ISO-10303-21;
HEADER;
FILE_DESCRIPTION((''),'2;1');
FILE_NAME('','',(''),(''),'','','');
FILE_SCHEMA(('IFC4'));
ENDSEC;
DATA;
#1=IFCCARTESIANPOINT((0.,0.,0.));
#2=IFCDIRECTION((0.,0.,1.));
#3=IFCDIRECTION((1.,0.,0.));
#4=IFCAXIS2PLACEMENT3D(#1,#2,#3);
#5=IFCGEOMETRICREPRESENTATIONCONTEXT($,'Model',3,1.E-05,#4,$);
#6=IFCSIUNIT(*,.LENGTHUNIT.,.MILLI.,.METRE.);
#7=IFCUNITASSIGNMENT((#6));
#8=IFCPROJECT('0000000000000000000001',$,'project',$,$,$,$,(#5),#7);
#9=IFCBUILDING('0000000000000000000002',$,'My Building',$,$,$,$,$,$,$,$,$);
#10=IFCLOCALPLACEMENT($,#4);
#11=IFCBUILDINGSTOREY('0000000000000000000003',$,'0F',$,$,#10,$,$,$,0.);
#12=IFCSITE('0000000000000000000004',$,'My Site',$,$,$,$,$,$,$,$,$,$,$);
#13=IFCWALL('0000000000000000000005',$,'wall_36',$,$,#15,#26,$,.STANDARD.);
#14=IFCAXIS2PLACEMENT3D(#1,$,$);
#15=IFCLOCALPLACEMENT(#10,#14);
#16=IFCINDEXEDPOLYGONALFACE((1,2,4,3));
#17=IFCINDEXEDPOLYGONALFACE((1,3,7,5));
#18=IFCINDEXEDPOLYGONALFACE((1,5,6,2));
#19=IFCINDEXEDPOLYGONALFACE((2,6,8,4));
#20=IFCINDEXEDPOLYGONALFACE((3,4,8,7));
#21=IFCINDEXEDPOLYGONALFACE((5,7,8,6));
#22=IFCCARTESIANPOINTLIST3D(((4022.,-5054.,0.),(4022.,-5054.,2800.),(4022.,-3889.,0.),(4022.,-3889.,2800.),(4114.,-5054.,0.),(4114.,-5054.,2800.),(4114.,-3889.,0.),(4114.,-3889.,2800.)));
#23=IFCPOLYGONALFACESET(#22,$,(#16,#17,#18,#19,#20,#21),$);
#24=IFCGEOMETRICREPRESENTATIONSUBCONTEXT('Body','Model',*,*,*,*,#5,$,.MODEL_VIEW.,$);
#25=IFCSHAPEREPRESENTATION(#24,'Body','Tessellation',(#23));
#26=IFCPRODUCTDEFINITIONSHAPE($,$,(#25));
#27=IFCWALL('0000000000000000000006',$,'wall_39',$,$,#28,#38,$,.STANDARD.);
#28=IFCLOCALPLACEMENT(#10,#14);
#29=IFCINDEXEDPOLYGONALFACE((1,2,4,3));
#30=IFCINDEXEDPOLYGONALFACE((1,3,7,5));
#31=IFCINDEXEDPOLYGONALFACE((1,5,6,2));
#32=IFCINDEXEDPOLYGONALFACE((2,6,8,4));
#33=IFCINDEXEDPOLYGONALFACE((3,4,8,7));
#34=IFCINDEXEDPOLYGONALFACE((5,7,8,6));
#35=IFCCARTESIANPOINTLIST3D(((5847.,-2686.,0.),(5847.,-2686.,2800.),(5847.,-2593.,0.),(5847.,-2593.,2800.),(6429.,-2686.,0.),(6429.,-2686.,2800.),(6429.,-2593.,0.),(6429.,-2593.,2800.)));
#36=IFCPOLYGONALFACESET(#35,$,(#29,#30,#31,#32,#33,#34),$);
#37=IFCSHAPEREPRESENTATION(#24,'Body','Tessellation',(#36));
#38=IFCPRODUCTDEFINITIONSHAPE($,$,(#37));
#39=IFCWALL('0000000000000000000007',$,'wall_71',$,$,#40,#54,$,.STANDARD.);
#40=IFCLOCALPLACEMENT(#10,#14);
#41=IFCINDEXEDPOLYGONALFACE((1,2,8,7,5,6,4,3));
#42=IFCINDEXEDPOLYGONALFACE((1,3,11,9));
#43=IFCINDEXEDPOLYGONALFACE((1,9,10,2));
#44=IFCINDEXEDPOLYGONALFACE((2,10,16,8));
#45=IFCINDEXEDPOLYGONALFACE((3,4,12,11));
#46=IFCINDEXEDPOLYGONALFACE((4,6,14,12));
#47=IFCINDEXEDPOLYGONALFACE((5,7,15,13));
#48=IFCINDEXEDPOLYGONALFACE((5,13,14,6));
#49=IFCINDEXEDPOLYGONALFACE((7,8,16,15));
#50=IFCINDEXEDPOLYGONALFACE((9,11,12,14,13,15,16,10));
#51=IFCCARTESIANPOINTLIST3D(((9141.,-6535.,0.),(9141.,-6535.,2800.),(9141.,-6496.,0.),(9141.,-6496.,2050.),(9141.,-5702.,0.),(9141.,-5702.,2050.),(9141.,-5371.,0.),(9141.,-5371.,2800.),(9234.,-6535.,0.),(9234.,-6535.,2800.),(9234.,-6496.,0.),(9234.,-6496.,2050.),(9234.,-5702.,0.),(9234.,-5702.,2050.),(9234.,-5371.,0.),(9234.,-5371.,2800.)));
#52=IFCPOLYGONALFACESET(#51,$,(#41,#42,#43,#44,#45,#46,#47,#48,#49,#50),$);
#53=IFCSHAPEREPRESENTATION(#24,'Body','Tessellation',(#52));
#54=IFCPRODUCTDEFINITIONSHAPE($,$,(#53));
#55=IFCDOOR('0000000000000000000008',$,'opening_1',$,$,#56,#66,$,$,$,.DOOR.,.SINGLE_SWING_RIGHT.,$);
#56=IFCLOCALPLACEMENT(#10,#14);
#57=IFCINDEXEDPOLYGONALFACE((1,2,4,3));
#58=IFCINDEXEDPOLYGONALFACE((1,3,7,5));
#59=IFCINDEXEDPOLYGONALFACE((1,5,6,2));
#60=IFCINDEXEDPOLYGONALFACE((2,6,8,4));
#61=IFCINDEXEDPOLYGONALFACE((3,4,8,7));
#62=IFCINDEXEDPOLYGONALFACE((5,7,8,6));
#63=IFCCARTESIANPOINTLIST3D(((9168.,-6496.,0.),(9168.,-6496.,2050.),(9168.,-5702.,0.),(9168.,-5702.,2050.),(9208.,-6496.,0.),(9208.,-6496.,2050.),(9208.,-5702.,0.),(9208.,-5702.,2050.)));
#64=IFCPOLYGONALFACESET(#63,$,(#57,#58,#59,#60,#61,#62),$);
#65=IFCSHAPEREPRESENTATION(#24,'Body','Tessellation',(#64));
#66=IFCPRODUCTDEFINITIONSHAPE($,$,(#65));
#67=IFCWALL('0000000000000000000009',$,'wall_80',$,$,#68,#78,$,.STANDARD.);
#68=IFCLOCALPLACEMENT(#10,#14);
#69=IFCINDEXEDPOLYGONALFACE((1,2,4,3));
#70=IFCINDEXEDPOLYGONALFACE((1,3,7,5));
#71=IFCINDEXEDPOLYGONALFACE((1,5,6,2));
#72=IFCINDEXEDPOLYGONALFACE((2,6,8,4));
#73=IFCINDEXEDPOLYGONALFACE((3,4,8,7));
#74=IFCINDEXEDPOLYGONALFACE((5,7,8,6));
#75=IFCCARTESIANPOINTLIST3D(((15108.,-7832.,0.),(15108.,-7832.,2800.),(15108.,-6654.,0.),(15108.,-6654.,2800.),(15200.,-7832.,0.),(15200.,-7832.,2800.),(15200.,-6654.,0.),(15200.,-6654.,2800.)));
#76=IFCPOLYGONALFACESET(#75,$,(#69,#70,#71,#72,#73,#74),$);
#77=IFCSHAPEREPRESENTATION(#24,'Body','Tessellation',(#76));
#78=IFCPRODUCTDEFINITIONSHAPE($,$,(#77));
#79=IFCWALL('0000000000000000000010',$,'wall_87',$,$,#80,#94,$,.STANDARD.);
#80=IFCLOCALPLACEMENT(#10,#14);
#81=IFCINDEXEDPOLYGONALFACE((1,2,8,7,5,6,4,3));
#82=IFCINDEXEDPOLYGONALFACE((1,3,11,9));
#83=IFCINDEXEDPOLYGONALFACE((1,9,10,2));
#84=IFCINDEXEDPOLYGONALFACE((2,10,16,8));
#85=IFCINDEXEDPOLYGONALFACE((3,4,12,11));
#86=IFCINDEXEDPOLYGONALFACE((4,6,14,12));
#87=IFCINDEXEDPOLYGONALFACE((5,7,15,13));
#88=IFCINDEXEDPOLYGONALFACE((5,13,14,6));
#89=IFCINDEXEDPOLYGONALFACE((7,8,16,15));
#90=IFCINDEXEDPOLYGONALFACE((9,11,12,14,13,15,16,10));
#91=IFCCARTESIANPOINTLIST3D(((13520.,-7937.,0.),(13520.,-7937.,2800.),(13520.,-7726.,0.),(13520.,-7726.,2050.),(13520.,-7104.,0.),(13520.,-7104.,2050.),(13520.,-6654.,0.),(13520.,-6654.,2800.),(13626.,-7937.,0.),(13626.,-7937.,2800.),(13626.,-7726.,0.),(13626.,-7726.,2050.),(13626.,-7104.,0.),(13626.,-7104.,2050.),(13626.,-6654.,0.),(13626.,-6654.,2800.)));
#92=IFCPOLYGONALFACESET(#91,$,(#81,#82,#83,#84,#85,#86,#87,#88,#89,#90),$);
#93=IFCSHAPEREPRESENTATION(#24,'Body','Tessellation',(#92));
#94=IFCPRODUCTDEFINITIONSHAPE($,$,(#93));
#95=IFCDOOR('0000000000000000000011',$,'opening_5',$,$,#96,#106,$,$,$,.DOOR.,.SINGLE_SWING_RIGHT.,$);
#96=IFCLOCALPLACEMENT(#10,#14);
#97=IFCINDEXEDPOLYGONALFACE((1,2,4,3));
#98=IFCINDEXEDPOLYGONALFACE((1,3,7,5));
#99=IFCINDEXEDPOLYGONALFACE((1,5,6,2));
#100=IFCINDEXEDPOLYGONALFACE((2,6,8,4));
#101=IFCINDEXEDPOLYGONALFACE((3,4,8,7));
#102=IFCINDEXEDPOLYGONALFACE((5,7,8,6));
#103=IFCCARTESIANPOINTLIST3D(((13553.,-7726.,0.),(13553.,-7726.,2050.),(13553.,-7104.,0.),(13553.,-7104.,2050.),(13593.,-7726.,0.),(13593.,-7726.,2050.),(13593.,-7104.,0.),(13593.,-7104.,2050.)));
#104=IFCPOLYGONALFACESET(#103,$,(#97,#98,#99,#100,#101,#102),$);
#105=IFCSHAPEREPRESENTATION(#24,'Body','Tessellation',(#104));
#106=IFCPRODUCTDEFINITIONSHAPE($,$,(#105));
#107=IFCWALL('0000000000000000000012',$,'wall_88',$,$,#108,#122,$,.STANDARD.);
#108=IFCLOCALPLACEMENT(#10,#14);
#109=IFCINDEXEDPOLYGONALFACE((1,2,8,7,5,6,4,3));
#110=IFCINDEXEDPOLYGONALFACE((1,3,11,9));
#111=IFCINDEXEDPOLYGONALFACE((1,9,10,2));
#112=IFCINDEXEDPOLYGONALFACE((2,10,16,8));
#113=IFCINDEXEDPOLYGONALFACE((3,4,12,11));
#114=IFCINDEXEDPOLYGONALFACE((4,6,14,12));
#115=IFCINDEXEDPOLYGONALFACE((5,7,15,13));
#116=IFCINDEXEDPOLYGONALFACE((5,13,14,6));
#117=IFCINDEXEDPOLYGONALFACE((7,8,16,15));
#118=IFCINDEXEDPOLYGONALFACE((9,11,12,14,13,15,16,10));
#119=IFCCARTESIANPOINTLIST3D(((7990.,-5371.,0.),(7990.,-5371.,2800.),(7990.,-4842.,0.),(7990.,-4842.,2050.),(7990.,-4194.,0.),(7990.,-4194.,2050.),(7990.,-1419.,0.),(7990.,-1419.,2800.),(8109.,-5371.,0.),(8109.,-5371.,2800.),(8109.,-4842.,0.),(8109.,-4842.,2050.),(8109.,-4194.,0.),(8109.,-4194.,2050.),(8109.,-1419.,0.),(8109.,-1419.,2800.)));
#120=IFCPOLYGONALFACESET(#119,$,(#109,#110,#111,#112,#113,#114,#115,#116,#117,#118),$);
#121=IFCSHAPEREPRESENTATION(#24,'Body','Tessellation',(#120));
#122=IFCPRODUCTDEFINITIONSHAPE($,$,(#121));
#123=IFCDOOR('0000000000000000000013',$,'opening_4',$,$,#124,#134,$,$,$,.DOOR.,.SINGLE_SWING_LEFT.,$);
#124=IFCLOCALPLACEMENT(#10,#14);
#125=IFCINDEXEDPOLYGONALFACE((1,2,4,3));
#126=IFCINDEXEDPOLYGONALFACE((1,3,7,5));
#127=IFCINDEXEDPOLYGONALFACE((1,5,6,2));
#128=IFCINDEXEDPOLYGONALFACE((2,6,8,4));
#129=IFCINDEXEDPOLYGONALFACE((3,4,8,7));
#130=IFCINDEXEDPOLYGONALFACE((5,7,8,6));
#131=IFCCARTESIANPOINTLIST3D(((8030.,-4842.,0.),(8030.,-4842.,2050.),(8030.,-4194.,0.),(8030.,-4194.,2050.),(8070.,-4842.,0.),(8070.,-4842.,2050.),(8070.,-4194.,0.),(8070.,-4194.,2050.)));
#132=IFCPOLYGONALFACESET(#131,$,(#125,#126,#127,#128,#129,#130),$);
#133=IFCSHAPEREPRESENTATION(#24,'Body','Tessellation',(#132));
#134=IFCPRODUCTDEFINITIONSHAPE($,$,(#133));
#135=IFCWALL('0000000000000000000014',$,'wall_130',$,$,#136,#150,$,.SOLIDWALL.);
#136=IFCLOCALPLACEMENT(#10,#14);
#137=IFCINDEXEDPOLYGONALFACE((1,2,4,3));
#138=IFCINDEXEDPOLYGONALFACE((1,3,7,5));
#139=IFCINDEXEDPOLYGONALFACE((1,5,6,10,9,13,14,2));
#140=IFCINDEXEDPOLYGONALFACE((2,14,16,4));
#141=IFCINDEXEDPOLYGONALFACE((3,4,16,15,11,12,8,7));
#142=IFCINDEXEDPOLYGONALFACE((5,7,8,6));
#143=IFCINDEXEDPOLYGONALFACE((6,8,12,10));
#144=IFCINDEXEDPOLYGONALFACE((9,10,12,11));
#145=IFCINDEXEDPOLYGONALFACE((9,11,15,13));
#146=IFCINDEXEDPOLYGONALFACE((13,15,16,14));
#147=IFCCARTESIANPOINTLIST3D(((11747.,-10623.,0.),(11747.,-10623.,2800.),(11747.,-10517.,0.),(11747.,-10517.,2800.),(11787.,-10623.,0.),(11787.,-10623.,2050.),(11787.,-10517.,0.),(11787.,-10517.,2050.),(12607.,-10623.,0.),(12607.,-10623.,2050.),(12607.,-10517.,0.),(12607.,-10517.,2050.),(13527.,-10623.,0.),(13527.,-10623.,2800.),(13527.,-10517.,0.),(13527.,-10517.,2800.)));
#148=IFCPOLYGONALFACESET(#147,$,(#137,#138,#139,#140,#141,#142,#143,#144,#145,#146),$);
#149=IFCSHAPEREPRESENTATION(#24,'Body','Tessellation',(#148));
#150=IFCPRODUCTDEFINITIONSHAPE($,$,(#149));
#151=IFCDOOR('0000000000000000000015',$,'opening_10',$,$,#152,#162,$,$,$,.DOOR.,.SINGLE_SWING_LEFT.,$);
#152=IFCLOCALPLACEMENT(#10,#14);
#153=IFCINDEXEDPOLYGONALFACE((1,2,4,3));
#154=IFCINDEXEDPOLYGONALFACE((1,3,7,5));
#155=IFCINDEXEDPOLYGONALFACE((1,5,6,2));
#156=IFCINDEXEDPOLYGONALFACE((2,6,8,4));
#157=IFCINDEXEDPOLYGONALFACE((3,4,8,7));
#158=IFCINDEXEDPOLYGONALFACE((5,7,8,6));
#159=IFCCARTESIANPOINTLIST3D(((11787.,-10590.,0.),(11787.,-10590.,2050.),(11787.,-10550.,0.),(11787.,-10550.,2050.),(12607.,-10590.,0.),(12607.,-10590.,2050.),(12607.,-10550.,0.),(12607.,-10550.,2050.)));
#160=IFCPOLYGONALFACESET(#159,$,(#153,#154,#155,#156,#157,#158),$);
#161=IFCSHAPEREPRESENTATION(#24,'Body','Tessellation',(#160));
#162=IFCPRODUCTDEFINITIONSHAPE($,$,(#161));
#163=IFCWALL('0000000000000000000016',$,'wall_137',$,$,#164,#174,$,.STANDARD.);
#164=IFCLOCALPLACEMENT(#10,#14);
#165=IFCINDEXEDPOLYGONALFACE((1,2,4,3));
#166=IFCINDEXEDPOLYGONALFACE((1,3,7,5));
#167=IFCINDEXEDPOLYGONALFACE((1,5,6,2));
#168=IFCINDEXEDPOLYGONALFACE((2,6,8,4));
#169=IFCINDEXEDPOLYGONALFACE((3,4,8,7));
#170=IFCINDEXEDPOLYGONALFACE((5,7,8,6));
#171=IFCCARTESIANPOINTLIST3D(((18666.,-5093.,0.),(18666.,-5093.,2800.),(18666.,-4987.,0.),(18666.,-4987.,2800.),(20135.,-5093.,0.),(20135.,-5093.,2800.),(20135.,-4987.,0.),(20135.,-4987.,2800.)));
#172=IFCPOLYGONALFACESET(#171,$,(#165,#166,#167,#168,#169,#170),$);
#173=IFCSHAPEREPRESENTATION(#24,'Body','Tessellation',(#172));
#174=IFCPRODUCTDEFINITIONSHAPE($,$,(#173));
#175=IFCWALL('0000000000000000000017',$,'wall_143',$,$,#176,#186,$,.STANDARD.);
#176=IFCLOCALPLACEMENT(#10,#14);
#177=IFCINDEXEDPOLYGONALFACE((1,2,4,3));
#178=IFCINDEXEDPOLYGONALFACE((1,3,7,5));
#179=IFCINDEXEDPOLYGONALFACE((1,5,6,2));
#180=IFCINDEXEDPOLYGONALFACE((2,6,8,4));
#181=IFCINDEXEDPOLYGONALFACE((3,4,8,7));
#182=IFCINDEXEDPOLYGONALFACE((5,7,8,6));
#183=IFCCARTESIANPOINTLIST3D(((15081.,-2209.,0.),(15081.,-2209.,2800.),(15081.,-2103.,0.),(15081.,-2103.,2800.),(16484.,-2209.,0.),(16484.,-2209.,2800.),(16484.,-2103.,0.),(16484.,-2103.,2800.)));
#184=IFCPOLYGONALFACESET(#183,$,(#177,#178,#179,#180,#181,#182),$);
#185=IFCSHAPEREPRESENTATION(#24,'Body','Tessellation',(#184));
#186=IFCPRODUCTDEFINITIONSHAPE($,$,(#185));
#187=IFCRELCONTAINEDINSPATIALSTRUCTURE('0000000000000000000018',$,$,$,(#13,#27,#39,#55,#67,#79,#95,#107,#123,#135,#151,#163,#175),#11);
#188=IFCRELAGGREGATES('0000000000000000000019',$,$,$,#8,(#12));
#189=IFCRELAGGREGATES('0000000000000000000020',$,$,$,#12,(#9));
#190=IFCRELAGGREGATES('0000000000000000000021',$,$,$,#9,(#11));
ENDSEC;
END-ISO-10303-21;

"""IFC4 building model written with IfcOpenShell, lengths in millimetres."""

from ifc_helpers import new_model, si_unit, origin_with_axes, place, context, subcontext, project, spatial, indexed_curve, outline, extrude, element, fill, save


model = new_model("IFC4")

# Units and contexts
model_context = context("Model", 3, precision=1e-05, world=origin_with_axes())
body_context = subcontext(model_context, "Body", "Model", "MODEL_VIEW")
ifc_project = project(units=[si_unit("LENGTHUNIT", "METRE", prefix="MILLI")], contexts=[model_context])

# Site, building, storey
site = spatial("IfcSite", under=ifc_project, Name="My Site")
building = spatial("IfcBuilding", under=site, Name="My Building")
storey_placement = place(None, origin_with_axes())
storey = spatial("IfcBuildingStorey", under=building, at=storey_placement, Name="0F", Elevation=0.0)

# Walls
wall_1_placement = place(storey_placement, origin_with_axes())
element("IfcWall", 1, at=wall_1_placement, inside=storey, Name="wall_36", PredefinedType="STANDARD", context=body_context, shape_type="SweptSolid", body=[
    extrude(outline(indexed_curve([(4022.0, -3889.0), (4022.0, -5054.0), (4114.0, -5054.0), (4114.0, -3889.0), (4022.0, -3889.0)])), None, (0.0, 0.0, 1.0), 2800.0),
])
wall_2_placement = place(storey_placement, origin_with_axes())
element("IfcWall", 2, at=wall_2_placement, inside=storey, Name="wall_39", PredefinedType="STANDARD", context=body_context, shape_type="SweptSolid", body=[
    extrude(outline(indexed_curve([(5847.0, -2686.0), (6429.0, -2686.0), (6429.0, -2593.0), (5847.0, -2593.0), (5847.0, -2686.0)])), None, (0.0, 0.0, 1.0), 2800.0),
])

# Wall, opening, door
wall_3_placement = place(storey_placement, origin_with_axes())
wall_3 = element("IfcWall", 3, at=wall_3_placement, inside=storey, Name="wall_71", PredefinedType="STANDARD", context=body_context, shape_type="SweptSolid", body=[
    extrude(outline(indexed_curve([(9141.0, -5371.0), (9141.0, -6535.0), (9234.0, -6535.0), (9234.0, -5371.0), (9141.0, -5371.0)])), None, (0.0, 0.0, 1.0), 2800.0),
])
opening_1_placement = place(wall_3_placement, origin_with_axes())
opening_1 = element("IfcOpeningElement", 4, at=opening_1_placement, cuts=wall_3, ObjectType="Opening", context=body_context, shape_type="SweptSolid", body=[
    extrude(outline(indexed_curve([(9075.0, -6496.0), (9300.0, -6496.0), (9300.0, -5702.0), (9075.0, -5702.0), (9075.0, -6496.0)])), None, (0.0, 0.0, 1.0), 2050.0),
])
door_1_placement = place(opening_1_placement, origin_with_axes())
door_1 = element("IfcDoor", 5, at=door_1_placement, inside=storey, Name="opening_1", OperationType="SINGLE_SWING_RIGHT", PredefinedType="DOOR", context=body_context, shape_type="SweptSolid", body=[
    extrude(outline(indexed_curve([(9168.0, -6496.0), (9208.0, -6496.0), (9208.0, -5702.0), (9168.0, -5702.0), (9168.0, -6496.0)])), None, (0.0, 0.0, 1.0), 2050.0),
])
fill(opening_1, door_1)

# Wall
wall_4_placement = place(storey_placement, origin_with_axes())
element("IfcWall", 6, at=wall_4_placement, inside=storey, Name="wall_80", PredefinedType="STANDARD", context=body_context, shape_type="SweptSolid", body=[
    extrude(outline(indexed_curve([(15108.0, -6654.0), (15108.0, -7832.0), (15200.0, -7832.0), (15200.0, -6654.0), (15108.0, -6654.0)])), None, (0.0, 0.0, 1.0), 2800.0),
])

# Walls, openings, doors
wall_5_placement = place(storey_placement, origin_with_axes())
wall_5 = element("IfcWall", 7, at=wall_5_placement, inside=storey, Name="wall_87", PredefinedType="STANDARD", context=body_context, shape_type="SweptSolid", body=[
    extrude(outline(indexed_curve([(13520.0, -6654.0), (13520.0, -7937.0), (13626.0, -7937.0), (13626.0, -6654.0), (13520.0, -6654.0)])), None, (0.0, 0.0, 1.0), 2800.0),
])
opening_2_placement = place(wall_5_placement, origin_with_axes())
opening_2 = element("IfcOpeningElement", 8, at=opening_2_placement, cuts=wall_5, ObjectType="Opening", context=body_context, shape_type="SweptSolid", body=[
    extrude(outline(indexed_curve([(13454.0, -7726.0), (13692.0, -7726.0), (13692.0, -7104.0), (13454.0, -7104.0), (13454.0, -7726.0)])), None, (0.0, 0.0, 1.0), 2050.0),
])
door_2_placement = place(opening_2_placement, origin_with_axes())
door_2 = element("IfcDoor", 9, at=door_2_placement, inside=storey, Name="opening_5", OperationType="SINGLE_SWING_RIGHT", PredefinedType="DOOR", context=body_context, shape_type="SweptSolid", body=[
    extrude(outline(indexed_curve([(13553.0, -7726.0), (13593.0, -7726.0), (13593.0, -7104.0), (13553.0, -7104.0), (13553.0, -7726.0)])), None, (0.0, 0.0, 1.0), 2050.0),
])
fill(opening_2, door_2)
wall_6_placement = place(storey_placement, origin_with_axes())
wall_6 = element("IfcWall", 10, at=wall_6_placement, inside=storey, Name="wall_88", PredefinedType="STANDARD", context=body_context, shape_type="SweptSolid", body=[
    extrude(outline(indexed_curve([(7990.0, -1419.0), (7990.0, -5371.0), (8109.0, -5371.0), (8109.0, -1419.0), (7990.0, -1419.0)])), None, (0.0, 0.0, 1.0), 2800.0),
])
opening_3_placement = place(wall_6_placement, origin_with_axes())
opening_3 = element("IfcOpeningElement", 11, at=opening_3_placement, cuts=wall_6, ObjectType="Opening", context=body_context, shape_type="SweptSolid", body=[
    extrude(outline(indexed_curve([(7924.0, -4842.0), (8176.0, -4842.0), (8176.0, -4194.0), (7924.0, -4194.0), (7924.0, -4842.0)])), None, (0.0, 0.0, 1.0), 2050.0),
])
door_3_placement = place(opening_3_placement, origin_with_axes())
door_3 = element("IfcDoor", 12, at=door_3_placement, inside=storey, Name="opening_4", OperationType="SINGLE_SWING_LEFT", PredefinedType="DOOR", context=body_context, shape_type="SweptSolid", body=[
    extrude(outline(indexed_curve([(8030.0, -4842.0), (8070.0, -4842.0), (8070.0, -4194.0), (8030.0, -4194.0), (8030.0, -4842.0)])), None, (0.0, 0.0, 1.0), 2050.0),
])
fill(opening_3, door_3)
wall_7_placement = place(storey_placement, origin_with_axes())
wall_7 = element("IfcWall", 13, at=wall_7_placement, inside=storey, Name="wall_130", PredefinedType="SOLIDWALL", context=body_context, shape_type="SweptSolid", body=[
    extrude(outline(indexed_curve([(11747.0, -10623.0), (13527.0, -10623.0), (13527.0, -10517.0), (11747.0, -10517.0), (11747.0, -10623.0)])), None, (0.0, 0.0, 1.0), 2800.0),
])
opening_4_placement = place(wall_7_placement, origin_with_axes())
opening_4 = element("IfcOpeningElement", 14, at=opening_4_placement, cuts=wall_7, ObjectType="Opening", context=body_context, shape_type="SweptSolid", body=[
    extrude(outline(indexed_curve([(12607.0, -10689.0), (12607.0, -10451.0), (11787.0, -10451.0), (11787.0, -10689.0), (12607.0, -10689.0)])), None, (0.0, 0.0, 1.0), 2050.0),
])
door_4_placement = place(opening_4_placement, origin_with_axes())
door_4 = element("IfcDoor", 15, at=door_4_placement, inside=storey, Name="opening_10", OperationType="SINGLE_SWING_LEFT", PredefinedType="DOOR", context=body_context, shape_type="SweptSolid", body=[
    extrude(outline(indexed_curve([(12607.0, -10590.0), (12607.0, -10550.0), (11787.0, -10550.0), (11787.0, -10590.0), (12607.0, -10590.0)])), None, (0.0, 0.0, 1.0), 2050.0),
])
fill(opening_4, door_4)

# Walls
wall_8_placement = place(storey_placement, origin_with_axes())
element("IfcWall", 16, at=wall_8_placement, inside=storey, Name="wall_137", PredefinedType="STANDARD", context=body_context, shape_type="SweptSolid", body=[
    extrude(outline(indexed_curve([(18666.0, -5093.0), (20135.0, -5093.0), (20135.0, -4987.0), (18666.0, -4987.0), (18666.0, -5093.0)])), None, (0.0, 0.0, 1.0), 2800.0),
])
wall_9_placement = place(storey_placement, origin_with_axes())
element("IfcWall", 17, at=wall_9_placement, inside=storey, Name="wall_143", PredefinedType="STANDARD", context=body_context, shape_type="SweptSolid", body=[
    extrude(outline(indexed_curve([(15081.0, -2209.0), (16484.0, -2209.0), (16484.0, -2103.0), (15081.0, -2103.0), (15081.0, -2209.0)])), None, (0.0, 0.0, 1.0), 2800.0),
])

save(model, "model.ifc")
